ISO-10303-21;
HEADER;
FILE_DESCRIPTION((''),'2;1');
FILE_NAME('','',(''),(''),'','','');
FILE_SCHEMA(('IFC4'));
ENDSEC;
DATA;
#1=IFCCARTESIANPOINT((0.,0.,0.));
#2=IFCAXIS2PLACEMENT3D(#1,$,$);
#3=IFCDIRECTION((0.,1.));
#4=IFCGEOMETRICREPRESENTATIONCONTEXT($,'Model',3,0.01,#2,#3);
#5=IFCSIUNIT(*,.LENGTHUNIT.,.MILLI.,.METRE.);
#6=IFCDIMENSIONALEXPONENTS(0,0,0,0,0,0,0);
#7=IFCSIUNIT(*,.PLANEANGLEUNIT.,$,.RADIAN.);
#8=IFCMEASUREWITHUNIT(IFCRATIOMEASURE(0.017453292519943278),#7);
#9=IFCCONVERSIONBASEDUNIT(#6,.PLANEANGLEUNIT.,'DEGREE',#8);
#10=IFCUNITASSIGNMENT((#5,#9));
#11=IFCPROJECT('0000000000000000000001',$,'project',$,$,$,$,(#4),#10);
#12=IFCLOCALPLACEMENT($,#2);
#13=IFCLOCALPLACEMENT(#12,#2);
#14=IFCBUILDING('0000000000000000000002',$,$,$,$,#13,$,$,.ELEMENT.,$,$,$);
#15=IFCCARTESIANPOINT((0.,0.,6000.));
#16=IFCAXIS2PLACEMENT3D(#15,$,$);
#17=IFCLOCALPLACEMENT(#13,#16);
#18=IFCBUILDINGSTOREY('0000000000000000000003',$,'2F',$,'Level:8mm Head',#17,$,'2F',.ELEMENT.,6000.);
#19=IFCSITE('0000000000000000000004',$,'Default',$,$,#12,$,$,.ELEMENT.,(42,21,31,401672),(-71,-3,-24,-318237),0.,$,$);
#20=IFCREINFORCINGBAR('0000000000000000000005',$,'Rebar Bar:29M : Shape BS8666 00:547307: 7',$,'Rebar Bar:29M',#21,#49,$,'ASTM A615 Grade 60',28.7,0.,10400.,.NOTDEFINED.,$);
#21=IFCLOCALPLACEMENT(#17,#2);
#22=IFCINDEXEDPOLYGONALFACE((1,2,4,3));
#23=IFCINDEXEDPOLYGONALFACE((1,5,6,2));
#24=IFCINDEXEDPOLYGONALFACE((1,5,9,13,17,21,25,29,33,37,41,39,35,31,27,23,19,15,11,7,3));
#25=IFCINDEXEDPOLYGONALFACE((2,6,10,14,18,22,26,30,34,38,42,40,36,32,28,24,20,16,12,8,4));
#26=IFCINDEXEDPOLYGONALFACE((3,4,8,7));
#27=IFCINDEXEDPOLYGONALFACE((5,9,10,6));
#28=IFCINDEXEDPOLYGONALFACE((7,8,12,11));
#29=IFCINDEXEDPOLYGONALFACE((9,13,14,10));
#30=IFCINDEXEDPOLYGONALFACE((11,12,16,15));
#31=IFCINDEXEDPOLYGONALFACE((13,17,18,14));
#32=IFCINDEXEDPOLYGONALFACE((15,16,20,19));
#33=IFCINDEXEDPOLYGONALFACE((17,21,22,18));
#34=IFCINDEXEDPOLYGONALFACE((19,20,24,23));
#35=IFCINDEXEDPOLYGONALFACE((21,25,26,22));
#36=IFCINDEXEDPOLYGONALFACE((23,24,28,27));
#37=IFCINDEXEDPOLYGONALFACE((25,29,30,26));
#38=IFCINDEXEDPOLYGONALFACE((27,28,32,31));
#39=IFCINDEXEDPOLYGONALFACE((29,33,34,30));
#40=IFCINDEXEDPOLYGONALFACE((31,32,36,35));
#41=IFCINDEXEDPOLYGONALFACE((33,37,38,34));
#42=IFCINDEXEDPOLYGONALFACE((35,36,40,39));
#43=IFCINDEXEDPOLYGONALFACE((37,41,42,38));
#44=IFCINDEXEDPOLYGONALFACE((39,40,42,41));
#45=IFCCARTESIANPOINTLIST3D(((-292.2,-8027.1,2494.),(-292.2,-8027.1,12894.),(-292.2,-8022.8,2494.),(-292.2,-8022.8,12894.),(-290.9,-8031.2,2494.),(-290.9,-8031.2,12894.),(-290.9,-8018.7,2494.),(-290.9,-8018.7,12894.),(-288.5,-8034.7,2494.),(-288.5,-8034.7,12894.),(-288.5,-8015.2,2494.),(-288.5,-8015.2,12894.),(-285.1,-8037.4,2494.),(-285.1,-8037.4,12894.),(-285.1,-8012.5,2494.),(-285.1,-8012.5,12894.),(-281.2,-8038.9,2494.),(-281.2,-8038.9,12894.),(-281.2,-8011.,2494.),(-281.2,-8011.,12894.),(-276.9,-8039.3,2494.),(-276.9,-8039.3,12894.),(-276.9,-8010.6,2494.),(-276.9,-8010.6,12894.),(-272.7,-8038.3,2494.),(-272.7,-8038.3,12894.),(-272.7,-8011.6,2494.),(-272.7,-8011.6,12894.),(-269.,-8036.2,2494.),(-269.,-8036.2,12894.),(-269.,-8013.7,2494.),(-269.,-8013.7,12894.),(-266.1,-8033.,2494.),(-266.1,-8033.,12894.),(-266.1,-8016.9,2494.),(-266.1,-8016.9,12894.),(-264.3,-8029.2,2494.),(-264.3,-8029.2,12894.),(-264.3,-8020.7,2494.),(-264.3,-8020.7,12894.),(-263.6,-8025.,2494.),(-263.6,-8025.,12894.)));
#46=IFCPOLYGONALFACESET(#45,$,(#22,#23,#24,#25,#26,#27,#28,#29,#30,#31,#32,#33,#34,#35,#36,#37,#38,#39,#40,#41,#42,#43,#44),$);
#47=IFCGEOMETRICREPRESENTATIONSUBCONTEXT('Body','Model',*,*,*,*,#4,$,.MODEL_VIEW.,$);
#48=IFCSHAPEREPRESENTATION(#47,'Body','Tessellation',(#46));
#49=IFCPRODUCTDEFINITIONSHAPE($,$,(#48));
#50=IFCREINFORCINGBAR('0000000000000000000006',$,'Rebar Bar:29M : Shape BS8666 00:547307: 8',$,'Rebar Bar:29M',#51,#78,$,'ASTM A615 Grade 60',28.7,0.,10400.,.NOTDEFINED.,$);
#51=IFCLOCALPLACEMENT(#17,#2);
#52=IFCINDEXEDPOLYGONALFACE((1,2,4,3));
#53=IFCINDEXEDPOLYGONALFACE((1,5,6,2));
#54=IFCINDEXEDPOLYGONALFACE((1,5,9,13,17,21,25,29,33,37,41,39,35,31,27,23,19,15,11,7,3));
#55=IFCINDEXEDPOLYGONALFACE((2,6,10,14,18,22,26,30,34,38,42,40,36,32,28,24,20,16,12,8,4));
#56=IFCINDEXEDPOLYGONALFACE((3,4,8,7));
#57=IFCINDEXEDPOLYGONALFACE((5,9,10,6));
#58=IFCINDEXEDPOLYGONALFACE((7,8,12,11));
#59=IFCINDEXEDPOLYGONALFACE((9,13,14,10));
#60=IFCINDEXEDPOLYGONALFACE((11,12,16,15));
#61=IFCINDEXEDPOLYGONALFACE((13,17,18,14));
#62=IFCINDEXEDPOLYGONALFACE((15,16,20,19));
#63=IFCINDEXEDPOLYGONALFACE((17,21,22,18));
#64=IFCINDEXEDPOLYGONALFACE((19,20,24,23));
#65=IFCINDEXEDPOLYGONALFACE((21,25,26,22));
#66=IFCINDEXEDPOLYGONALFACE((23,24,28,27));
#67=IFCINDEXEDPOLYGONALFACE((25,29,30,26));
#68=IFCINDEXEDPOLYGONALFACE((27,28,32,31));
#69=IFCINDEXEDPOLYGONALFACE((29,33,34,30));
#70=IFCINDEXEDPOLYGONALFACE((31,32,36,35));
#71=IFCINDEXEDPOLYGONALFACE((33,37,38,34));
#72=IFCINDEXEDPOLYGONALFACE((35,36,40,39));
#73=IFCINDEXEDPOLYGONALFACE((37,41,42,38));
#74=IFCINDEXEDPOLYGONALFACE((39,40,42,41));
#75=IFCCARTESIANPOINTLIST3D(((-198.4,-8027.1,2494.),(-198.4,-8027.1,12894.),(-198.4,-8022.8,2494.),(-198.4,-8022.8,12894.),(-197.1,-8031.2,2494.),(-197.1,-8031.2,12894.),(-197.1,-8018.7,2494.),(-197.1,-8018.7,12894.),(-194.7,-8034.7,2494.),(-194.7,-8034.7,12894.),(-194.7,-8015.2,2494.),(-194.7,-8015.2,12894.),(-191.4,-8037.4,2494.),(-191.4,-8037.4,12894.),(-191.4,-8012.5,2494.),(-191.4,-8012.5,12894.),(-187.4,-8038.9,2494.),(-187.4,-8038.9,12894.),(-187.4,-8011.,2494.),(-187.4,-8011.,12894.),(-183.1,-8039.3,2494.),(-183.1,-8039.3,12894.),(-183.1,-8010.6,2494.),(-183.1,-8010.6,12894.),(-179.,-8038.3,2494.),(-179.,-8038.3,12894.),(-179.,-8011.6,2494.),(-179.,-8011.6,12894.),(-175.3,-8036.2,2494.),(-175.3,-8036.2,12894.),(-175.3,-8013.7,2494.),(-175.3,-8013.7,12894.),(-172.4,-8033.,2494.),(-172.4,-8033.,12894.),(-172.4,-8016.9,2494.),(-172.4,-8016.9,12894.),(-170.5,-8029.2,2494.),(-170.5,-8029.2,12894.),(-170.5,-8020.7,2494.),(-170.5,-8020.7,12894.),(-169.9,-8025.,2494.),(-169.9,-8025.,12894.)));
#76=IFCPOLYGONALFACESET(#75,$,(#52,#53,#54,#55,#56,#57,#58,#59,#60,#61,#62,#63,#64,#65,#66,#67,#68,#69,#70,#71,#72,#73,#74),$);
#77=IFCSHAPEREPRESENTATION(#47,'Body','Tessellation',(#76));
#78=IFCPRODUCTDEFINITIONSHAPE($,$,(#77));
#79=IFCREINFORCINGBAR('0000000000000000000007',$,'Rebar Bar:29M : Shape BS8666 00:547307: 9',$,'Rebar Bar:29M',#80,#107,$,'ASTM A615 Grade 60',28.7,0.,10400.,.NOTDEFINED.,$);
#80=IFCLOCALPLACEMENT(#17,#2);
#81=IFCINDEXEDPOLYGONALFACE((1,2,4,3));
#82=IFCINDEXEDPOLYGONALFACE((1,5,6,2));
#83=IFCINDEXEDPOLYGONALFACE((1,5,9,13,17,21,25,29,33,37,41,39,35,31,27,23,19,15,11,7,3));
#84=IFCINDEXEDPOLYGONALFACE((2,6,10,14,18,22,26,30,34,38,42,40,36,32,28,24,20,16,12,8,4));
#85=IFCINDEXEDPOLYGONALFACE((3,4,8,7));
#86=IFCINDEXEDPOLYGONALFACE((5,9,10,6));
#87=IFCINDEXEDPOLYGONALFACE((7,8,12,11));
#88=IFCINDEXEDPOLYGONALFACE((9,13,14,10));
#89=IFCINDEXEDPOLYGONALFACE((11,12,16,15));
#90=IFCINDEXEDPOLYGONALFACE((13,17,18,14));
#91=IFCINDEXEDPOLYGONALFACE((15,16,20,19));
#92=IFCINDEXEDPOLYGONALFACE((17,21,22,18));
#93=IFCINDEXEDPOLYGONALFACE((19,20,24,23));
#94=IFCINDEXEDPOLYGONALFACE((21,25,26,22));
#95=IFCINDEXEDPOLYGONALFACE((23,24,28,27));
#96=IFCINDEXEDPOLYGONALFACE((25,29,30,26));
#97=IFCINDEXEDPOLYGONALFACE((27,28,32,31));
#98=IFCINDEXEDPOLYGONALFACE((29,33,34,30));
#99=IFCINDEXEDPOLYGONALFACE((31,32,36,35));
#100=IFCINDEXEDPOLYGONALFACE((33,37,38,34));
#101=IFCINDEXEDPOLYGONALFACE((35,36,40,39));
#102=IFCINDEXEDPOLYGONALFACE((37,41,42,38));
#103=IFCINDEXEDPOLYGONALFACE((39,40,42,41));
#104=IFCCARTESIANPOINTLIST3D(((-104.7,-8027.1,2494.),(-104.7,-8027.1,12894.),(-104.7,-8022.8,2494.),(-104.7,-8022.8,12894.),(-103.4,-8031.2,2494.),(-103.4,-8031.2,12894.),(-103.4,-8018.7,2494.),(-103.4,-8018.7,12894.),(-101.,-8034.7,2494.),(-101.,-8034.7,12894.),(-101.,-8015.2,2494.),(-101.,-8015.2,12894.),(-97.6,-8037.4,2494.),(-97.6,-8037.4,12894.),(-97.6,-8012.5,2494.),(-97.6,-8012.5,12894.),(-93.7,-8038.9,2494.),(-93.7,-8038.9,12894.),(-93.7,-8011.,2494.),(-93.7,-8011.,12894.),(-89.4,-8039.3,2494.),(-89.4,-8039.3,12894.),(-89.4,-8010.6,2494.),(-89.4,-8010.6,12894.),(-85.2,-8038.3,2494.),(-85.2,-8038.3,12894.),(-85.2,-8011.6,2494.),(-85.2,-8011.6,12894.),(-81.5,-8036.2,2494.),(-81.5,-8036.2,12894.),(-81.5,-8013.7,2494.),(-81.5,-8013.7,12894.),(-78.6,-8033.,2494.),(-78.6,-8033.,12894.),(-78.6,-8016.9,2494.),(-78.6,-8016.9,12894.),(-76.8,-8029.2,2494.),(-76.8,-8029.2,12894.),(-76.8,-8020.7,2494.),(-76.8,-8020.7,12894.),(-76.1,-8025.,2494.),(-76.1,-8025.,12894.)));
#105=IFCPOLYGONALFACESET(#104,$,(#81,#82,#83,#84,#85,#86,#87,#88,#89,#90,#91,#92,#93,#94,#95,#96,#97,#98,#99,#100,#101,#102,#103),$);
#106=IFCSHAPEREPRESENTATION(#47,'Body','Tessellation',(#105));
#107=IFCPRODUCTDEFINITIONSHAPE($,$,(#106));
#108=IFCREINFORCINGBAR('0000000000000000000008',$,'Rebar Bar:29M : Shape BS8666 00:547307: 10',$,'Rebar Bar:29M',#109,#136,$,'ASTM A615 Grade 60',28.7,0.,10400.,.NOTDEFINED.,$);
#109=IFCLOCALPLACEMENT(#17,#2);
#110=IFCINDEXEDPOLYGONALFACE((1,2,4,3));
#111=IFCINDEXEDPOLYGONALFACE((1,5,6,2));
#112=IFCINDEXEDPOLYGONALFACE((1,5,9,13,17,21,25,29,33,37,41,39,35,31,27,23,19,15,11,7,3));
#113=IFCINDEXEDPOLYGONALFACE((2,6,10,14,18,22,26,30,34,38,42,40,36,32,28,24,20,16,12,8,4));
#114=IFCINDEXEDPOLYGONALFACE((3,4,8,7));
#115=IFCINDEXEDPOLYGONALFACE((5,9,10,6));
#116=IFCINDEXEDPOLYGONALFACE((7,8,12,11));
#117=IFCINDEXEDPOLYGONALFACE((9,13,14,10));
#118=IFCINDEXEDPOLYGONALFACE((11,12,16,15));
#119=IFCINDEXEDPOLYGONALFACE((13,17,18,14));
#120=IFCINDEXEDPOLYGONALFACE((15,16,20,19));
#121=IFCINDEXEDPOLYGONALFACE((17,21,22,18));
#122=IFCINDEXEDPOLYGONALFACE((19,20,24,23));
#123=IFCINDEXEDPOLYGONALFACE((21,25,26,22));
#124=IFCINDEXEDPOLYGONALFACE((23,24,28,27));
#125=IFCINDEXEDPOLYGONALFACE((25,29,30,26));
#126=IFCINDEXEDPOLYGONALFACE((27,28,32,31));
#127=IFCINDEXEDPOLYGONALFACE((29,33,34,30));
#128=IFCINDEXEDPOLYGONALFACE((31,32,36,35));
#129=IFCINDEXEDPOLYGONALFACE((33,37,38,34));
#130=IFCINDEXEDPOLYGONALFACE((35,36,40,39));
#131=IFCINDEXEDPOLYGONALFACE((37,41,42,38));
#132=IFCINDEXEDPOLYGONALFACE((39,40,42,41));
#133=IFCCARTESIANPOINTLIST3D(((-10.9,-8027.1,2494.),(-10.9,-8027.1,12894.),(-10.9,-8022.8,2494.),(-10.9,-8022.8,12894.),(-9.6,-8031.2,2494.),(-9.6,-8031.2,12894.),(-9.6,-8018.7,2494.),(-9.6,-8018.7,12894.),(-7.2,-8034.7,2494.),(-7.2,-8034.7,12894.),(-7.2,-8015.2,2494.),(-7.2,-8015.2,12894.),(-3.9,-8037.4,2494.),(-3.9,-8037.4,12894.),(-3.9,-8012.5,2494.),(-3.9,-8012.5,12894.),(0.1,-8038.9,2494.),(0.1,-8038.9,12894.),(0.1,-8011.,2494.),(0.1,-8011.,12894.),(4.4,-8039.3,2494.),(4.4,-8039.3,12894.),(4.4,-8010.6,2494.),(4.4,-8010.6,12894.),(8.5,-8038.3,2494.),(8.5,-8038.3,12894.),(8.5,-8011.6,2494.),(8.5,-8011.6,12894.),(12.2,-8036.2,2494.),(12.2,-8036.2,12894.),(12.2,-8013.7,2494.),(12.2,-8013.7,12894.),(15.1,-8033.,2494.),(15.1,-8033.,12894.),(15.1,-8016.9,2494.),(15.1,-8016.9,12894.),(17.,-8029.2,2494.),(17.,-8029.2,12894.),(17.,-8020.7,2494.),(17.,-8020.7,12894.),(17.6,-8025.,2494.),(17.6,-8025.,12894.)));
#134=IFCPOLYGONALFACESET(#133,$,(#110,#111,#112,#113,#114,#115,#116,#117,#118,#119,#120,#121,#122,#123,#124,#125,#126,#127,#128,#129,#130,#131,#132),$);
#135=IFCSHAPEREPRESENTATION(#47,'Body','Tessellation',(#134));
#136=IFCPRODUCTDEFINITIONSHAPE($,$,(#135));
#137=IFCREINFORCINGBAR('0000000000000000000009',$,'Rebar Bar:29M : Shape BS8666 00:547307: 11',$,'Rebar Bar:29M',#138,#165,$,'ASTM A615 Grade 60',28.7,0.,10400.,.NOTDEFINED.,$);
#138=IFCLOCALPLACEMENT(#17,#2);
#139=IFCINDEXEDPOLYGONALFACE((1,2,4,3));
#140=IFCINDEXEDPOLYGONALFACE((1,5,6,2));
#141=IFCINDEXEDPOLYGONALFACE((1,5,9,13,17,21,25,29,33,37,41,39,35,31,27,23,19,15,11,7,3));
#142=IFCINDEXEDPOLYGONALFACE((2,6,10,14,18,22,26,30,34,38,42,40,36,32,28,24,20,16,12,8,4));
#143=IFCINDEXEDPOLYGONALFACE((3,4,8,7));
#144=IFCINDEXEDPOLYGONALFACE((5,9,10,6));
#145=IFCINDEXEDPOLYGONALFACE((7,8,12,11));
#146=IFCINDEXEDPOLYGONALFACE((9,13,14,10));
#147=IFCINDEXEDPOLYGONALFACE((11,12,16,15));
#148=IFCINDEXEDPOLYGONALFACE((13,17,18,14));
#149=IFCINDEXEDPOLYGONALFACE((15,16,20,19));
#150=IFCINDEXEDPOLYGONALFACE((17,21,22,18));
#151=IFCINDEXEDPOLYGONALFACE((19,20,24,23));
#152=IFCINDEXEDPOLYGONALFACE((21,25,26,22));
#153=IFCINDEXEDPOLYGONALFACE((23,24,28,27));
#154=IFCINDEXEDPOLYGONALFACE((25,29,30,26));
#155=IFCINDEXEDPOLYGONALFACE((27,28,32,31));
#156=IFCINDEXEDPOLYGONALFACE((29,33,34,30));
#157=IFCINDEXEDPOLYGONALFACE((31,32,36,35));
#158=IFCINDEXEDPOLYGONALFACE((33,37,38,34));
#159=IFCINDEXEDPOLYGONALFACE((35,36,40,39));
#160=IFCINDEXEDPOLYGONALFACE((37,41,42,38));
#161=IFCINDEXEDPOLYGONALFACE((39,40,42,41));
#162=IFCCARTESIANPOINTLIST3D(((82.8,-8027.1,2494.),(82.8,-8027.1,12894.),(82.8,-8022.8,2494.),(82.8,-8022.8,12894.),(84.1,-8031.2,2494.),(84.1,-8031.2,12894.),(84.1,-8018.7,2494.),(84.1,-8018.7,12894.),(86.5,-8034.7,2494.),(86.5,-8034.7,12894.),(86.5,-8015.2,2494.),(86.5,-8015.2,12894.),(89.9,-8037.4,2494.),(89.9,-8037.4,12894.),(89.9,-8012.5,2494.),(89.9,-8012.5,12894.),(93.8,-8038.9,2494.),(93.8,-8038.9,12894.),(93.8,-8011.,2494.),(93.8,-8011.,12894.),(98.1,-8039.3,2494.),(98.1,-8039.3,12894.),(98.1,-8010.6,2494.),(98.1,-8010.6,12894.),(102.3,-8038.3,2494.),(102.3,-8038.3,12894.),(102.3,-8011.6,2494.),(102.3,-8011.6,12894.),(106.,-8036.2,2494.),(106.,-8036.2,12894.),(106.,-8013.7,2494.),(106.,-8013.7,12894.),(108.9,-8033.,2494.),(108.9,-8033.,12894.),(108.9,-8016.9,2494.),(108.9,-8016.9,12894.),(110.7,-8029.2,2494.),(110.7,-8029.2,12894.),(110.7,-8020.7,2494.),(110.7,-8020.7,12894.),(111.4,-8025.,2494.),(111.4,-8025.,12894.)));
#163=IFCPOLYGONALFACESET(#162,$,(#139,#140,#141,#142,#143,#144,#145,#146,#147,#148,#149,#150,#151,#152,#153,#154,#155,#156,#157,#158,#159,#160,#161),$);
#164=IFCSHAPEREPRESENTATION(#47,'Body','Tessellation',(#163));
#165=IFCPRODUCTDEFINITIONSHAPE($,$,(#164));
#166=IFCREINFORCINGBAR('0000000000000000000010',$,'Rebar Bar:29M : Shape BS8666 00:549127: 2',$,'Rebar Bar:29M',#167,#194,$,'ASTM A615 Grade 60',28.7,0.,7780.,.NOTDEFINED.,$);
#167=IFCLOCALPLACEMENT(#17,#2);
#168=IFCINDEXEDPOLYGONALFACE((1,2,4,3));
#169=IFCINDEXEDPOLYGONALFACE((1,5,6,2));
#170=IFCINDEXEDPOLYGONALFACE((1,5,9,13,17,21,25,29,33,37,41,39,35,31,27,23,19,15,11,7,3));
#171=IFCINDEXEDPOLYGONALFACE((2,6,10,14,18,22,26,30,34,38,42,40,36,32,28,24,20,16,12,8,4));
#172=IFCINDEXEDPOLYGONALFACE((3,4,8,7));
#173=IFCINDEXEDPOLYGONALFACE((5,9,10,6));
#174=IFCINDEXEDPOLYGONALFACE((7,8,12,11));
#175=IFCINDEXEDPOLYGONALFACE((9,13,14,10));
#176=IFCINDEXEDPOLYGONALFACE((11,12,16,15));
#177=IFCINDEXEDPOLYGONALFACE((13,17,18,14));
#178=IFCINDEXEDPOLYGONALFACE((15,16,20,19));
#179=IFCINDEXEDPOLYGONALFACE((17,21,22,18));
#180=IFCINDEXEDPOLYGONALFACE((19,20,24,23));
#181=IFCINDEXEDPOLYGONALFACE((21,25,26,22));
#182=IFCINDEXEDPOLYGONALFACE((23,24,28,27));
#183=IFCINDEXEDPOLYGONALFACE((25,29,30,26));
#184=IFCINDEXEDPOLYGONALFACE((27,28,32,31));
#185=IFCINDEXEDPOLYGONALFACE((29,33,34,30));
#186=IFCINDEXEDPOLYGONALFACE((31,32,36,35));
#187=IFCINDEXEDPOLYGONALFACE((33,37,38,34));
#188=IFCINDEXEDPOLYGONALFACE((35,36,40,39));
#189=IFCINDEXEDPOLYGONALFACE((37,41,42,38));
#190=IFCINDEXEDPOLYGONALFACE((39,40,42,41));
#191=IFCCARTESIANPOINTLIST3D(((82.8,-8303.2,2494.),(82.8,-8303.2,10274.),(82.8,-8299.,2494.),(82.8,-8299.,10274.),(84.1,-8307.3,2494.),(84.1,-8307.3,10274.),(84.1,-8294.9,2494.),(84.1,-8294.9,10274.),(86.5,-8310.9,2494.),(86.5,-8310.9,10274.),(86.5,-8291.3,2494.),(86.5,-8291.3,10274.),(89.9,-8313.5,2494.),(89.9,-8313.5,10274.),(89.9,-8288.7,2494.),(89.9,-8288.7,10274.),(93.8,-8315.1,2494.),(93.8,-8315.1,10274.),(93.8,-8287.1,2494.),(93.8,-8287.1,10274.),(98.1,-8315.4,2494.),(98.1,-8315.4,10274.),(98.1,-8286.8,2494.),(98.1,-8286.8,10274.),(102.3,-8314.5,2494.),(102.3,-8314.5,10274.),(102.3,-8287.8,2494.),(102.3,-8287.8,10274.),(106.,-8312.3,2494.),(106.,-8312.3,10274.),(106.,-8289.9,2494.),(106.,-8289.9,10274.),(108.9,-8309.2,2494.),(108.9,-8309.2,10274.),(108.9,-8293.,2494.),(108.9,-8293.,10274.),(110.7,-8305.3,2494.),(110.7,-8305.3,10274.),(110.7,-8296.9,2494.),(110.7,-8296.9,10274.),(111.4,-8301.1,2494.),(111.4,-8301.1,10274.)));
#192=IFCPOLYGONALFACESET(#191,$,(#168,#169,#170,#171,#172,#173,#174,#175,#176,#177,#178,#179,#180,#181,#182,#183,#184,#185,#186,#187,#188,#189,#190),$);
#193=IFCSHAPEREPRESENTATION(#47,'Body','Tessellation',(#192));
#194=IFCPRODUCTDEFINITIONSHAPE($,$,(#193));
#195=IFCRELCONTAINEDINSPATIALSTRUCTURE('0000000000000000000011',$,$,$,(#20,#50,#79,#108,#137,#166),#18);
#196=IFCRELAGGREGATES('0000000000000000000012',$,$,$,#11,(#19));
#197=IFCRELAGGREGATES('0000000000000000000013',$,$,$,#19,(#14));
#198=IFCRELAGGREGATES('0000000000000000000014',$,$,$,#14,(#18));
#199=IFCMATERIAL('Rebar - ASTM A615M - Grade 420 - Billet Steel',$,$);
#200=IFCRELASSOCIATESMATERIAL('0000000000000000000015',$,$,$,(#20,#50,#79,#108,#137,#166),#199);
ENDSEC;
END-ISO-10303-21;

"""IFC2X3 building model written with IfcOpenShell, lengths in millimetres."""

from ifc_helpers import new_model, entity, si_unit, converted_unit, direction, frame, origin, place, context, subcontext, project, spatial, material, element, save


model = new_model("IFC2X3")

# Units and contexts
model_context = context("Model", 3, precision=0.01, world=origin(), true_north=direction((0.0, 1.0)))
body_context = subcontext(model_context, "Body", "Model", "MODEL_VIEW")
ifc_project = project(units=[si_unit("LENGTHUNIT", "METRE", prefix="MILLI"), converted_unit("PLANEANGLEUNIT", "DEGREE", entity("IfcRatioMeasure", 0.017453292519943278), si_unit("PLANEANGLEUNIT", "RADIAN"), dimensions=[0, 0, 0, 0, 0, 0, 0])], contexts=[model_context])

# Site, building, storey
site_placement = place(None, origin())
site = spatial("IfcSite", under=ifc_project, at=site_placement, Name="Default", CompositionType="ELEMENT", RefLatitude=(42, 21, 31, 401672), RefLongitude=(-71, -3, -24, -318237), RefElevation=0.0)
building_placement = place(site_placement, origin())
building = spatial("IfcBuilding", under=site, at=building_placement, CompositionType="ELEMENT")
storey_placement = place(building_placement, frame((0.0, 0.0, 6000.0)))
storey = spatial("IfcBuildingStorey", under=building, at=storey_placement, Name="2F", ObjectType="Level:8mm Head", LongName="2F", CompositionType="ELEMENT", Elevation=6000.0)

# Reinforcing bars
ifc_material = material(Name="Rebar - ASTM A615M - Grade 420 - Billet Steel")
reinforcing_bar_1_placement = place(storey_placement, origin())
element("IfcReinforcingBar", 1, at=reinforcing_bar_1_placement, inside=storey, material=ifc_material, Name="Rebar Bar:29M : Shape BS8666 00:547307: 7", SteelGrade="ASTM A615 Grade 60", ObjectType="Rebar Bar:29M", BarLength=10400.0, BarRole="NOTDEFINED", CrossSectionArea=0.0, NominalDiameter=28.7, context=body_context, shape_type="AdvancedSweptSolid", body=[
    entity("IfcSweptDiskSolid", entity("IfcCompositeCurve", [entity("IfcCompositeCurveSegment", "CONTINUOUS", True, entity("IfcPolyline", [entity("IfcCartesianPoint", [-278.0, -8025.0, 2494.0]), entity("IfcCartesianPoint", [-278.0, -8025.0, 12894.0])]))], False), 14.3, None, 0.0, 1.0),
])
reinforcing_bar_2_placement = place(storey_placement, origin())
element("IfcReinforcingBar", 2, at=reinforcing_bar_2_placement, inside=storey, material=ifc_material, Name="Rebar Bar:29M : Shape BS8666 00:547307: 8", SteelGrade="ASTM A615 Grade 60", ObjectType="Rebar Bar:29M", BarLength=10400.0, BarRole="NOTDEFINED", CrossSectionArea=0.0, NominalDiameter=28.7, context=body_context, shape_type="AdvancedSweptSolid", body=[
    entity("IfcSweptDiskSolid", entity("IfcCompositeCurve", [entity("IfcCompositeCurveSegment", "CONTINUOUS", True, entity("IfcPolyline", [entity("IfcCartesianPoint", [-184.2, -8025.0, 2494.0]), entity("IfcCartesianPoint", [-184.2, -8025.0, 12894.0])]))], False), 14.3, None, 0.0, 1.0),
])
reinforcing_bar_3_placement = place(storey_placement, origin())
element("IfcReinforcingBar", 3, at=reinforcing_bar_3_placement, inside=storey, material=ifc_material, Name="Rebar Bar:29M : Shape BS8666 00:547307: 9", SteelGrade="ASTM A615 Grade 60", ObjectType="Rebar Bar:29M", BarLength=10400.0, BarRole="NOTDEFINED", CrossSectionArea=0.0, NominalDiameter=28.7, context=body_context, shape_type="AdvancedSweptSolid", body=[
    entity("IfcSweptDiskSolid", entity("IfcCompositeCurve", [entity("IfcCompositeCurveSegment", "CONTINUOUS", True, entity("IfcPolyline", [entity("IfcCartesianPoint", [-90.5, -8025.0, 2494.0]), entity("IfcCartesianPoint", [-90.5, -8025.0, 12894.0])]))], False), 14.3, None, 0.0, 1.0),
])
reinforcing_bar_4_placement = place(storey_placement, origin())
element("IfcReinforcingBar", 4, at=reinforcing_bar_4_placement, inside=storey, material=ifc_material, Name="Rebar Bar:29M : Shape BS8666 00:547307: 10", SteelGrade="ASTM A615 Grade 60", ObjectType="Rebar Bar:29M", BarLength=10400.0, BarRole="NOTDEFINED", CrossSectionArea=0.0, NominalDiameter=28.7, context=body_context, shape_type="AdvancedSweptSolid", body=[
    entity("IfcSweptDiskSolid", entity("IfcCompositeCurve", [entity("IfcCompositeCurveSegment", "CONTINUOUS", True, entity("IfcPolyline", [entity("IfcCartesianPoint", [3.3, -8025.0, 2494.0]), entity("IfcCartesianPoint", [3.3, -8025.0, 12894.0])]))], False), 14.3, None, 0.0, 1.0),
])
reinforcing_bar_5_placement = place(storey_placement, origin())
element("IfcReinforcingBar", 5, at=reinforcing_bar_5_placement, inside=storey, material=ifc_material, Name="Rebar Bar:29M : Shape BS8666 00:547307: 11", SteelGrade="ASTM A615 Grade 60", ObjectType="Rebar Bar:29M", BarLength=10400.0, BarRole="NOTDEFINED", CrossSectionArea=0.0, NominalDiameter=28.7, context=body_context, shape_type="AdvancedSweptSolid", body=[
    entity("IfcSweptDiskSolid", entity("IfcCompositeCurve", [entity("IfcCompositeCurveSegment", "CONTINUOUS", True, entity("IfcPolyline", [entity("IfcCartesianPoint", [97.0, -8025.0, 2494.0]), entity("IfcCartesianPoint", [97.0, -8025.0, 12894.0])]))], False), 14.3, None, 0.0, 1.0),
])
reinforcing_bar_6_placement = place(storey_placement, origin())
element("IfcReinforcingBar", 6, at=reinforcing_bar_6_placement, inside=storey, material=ifc_material, Name="Rebar Bar:29M : Shape BS8666 00:549127: 2", SteelGrade="ASTM A615 Grade 60", ObjectType="Rebar Bar:29M", BarLength=7780.0, BarRole="NOTDEFINED", CrossSectionArea=0.0, NominalDiameter=28.7, context=body_context, shape_type="AdvancedSweptSolid", body=[
    entity("IfcSweptDiskSolid", entity("IfcCompositeCurve", [entity("IfcCompositeCurveSegment", "CONTINUOUS", True, entity("IfcPolyline", [entity("IfcCartesianPoint", [97.0, -8301.1, 2494.0]), entity("IfcCartesianPoint", [97.0, -8301.1, 10274.0])]))], False), 14.3, None, 0.0, 1.0),
])

save(model, "model.ifc")
